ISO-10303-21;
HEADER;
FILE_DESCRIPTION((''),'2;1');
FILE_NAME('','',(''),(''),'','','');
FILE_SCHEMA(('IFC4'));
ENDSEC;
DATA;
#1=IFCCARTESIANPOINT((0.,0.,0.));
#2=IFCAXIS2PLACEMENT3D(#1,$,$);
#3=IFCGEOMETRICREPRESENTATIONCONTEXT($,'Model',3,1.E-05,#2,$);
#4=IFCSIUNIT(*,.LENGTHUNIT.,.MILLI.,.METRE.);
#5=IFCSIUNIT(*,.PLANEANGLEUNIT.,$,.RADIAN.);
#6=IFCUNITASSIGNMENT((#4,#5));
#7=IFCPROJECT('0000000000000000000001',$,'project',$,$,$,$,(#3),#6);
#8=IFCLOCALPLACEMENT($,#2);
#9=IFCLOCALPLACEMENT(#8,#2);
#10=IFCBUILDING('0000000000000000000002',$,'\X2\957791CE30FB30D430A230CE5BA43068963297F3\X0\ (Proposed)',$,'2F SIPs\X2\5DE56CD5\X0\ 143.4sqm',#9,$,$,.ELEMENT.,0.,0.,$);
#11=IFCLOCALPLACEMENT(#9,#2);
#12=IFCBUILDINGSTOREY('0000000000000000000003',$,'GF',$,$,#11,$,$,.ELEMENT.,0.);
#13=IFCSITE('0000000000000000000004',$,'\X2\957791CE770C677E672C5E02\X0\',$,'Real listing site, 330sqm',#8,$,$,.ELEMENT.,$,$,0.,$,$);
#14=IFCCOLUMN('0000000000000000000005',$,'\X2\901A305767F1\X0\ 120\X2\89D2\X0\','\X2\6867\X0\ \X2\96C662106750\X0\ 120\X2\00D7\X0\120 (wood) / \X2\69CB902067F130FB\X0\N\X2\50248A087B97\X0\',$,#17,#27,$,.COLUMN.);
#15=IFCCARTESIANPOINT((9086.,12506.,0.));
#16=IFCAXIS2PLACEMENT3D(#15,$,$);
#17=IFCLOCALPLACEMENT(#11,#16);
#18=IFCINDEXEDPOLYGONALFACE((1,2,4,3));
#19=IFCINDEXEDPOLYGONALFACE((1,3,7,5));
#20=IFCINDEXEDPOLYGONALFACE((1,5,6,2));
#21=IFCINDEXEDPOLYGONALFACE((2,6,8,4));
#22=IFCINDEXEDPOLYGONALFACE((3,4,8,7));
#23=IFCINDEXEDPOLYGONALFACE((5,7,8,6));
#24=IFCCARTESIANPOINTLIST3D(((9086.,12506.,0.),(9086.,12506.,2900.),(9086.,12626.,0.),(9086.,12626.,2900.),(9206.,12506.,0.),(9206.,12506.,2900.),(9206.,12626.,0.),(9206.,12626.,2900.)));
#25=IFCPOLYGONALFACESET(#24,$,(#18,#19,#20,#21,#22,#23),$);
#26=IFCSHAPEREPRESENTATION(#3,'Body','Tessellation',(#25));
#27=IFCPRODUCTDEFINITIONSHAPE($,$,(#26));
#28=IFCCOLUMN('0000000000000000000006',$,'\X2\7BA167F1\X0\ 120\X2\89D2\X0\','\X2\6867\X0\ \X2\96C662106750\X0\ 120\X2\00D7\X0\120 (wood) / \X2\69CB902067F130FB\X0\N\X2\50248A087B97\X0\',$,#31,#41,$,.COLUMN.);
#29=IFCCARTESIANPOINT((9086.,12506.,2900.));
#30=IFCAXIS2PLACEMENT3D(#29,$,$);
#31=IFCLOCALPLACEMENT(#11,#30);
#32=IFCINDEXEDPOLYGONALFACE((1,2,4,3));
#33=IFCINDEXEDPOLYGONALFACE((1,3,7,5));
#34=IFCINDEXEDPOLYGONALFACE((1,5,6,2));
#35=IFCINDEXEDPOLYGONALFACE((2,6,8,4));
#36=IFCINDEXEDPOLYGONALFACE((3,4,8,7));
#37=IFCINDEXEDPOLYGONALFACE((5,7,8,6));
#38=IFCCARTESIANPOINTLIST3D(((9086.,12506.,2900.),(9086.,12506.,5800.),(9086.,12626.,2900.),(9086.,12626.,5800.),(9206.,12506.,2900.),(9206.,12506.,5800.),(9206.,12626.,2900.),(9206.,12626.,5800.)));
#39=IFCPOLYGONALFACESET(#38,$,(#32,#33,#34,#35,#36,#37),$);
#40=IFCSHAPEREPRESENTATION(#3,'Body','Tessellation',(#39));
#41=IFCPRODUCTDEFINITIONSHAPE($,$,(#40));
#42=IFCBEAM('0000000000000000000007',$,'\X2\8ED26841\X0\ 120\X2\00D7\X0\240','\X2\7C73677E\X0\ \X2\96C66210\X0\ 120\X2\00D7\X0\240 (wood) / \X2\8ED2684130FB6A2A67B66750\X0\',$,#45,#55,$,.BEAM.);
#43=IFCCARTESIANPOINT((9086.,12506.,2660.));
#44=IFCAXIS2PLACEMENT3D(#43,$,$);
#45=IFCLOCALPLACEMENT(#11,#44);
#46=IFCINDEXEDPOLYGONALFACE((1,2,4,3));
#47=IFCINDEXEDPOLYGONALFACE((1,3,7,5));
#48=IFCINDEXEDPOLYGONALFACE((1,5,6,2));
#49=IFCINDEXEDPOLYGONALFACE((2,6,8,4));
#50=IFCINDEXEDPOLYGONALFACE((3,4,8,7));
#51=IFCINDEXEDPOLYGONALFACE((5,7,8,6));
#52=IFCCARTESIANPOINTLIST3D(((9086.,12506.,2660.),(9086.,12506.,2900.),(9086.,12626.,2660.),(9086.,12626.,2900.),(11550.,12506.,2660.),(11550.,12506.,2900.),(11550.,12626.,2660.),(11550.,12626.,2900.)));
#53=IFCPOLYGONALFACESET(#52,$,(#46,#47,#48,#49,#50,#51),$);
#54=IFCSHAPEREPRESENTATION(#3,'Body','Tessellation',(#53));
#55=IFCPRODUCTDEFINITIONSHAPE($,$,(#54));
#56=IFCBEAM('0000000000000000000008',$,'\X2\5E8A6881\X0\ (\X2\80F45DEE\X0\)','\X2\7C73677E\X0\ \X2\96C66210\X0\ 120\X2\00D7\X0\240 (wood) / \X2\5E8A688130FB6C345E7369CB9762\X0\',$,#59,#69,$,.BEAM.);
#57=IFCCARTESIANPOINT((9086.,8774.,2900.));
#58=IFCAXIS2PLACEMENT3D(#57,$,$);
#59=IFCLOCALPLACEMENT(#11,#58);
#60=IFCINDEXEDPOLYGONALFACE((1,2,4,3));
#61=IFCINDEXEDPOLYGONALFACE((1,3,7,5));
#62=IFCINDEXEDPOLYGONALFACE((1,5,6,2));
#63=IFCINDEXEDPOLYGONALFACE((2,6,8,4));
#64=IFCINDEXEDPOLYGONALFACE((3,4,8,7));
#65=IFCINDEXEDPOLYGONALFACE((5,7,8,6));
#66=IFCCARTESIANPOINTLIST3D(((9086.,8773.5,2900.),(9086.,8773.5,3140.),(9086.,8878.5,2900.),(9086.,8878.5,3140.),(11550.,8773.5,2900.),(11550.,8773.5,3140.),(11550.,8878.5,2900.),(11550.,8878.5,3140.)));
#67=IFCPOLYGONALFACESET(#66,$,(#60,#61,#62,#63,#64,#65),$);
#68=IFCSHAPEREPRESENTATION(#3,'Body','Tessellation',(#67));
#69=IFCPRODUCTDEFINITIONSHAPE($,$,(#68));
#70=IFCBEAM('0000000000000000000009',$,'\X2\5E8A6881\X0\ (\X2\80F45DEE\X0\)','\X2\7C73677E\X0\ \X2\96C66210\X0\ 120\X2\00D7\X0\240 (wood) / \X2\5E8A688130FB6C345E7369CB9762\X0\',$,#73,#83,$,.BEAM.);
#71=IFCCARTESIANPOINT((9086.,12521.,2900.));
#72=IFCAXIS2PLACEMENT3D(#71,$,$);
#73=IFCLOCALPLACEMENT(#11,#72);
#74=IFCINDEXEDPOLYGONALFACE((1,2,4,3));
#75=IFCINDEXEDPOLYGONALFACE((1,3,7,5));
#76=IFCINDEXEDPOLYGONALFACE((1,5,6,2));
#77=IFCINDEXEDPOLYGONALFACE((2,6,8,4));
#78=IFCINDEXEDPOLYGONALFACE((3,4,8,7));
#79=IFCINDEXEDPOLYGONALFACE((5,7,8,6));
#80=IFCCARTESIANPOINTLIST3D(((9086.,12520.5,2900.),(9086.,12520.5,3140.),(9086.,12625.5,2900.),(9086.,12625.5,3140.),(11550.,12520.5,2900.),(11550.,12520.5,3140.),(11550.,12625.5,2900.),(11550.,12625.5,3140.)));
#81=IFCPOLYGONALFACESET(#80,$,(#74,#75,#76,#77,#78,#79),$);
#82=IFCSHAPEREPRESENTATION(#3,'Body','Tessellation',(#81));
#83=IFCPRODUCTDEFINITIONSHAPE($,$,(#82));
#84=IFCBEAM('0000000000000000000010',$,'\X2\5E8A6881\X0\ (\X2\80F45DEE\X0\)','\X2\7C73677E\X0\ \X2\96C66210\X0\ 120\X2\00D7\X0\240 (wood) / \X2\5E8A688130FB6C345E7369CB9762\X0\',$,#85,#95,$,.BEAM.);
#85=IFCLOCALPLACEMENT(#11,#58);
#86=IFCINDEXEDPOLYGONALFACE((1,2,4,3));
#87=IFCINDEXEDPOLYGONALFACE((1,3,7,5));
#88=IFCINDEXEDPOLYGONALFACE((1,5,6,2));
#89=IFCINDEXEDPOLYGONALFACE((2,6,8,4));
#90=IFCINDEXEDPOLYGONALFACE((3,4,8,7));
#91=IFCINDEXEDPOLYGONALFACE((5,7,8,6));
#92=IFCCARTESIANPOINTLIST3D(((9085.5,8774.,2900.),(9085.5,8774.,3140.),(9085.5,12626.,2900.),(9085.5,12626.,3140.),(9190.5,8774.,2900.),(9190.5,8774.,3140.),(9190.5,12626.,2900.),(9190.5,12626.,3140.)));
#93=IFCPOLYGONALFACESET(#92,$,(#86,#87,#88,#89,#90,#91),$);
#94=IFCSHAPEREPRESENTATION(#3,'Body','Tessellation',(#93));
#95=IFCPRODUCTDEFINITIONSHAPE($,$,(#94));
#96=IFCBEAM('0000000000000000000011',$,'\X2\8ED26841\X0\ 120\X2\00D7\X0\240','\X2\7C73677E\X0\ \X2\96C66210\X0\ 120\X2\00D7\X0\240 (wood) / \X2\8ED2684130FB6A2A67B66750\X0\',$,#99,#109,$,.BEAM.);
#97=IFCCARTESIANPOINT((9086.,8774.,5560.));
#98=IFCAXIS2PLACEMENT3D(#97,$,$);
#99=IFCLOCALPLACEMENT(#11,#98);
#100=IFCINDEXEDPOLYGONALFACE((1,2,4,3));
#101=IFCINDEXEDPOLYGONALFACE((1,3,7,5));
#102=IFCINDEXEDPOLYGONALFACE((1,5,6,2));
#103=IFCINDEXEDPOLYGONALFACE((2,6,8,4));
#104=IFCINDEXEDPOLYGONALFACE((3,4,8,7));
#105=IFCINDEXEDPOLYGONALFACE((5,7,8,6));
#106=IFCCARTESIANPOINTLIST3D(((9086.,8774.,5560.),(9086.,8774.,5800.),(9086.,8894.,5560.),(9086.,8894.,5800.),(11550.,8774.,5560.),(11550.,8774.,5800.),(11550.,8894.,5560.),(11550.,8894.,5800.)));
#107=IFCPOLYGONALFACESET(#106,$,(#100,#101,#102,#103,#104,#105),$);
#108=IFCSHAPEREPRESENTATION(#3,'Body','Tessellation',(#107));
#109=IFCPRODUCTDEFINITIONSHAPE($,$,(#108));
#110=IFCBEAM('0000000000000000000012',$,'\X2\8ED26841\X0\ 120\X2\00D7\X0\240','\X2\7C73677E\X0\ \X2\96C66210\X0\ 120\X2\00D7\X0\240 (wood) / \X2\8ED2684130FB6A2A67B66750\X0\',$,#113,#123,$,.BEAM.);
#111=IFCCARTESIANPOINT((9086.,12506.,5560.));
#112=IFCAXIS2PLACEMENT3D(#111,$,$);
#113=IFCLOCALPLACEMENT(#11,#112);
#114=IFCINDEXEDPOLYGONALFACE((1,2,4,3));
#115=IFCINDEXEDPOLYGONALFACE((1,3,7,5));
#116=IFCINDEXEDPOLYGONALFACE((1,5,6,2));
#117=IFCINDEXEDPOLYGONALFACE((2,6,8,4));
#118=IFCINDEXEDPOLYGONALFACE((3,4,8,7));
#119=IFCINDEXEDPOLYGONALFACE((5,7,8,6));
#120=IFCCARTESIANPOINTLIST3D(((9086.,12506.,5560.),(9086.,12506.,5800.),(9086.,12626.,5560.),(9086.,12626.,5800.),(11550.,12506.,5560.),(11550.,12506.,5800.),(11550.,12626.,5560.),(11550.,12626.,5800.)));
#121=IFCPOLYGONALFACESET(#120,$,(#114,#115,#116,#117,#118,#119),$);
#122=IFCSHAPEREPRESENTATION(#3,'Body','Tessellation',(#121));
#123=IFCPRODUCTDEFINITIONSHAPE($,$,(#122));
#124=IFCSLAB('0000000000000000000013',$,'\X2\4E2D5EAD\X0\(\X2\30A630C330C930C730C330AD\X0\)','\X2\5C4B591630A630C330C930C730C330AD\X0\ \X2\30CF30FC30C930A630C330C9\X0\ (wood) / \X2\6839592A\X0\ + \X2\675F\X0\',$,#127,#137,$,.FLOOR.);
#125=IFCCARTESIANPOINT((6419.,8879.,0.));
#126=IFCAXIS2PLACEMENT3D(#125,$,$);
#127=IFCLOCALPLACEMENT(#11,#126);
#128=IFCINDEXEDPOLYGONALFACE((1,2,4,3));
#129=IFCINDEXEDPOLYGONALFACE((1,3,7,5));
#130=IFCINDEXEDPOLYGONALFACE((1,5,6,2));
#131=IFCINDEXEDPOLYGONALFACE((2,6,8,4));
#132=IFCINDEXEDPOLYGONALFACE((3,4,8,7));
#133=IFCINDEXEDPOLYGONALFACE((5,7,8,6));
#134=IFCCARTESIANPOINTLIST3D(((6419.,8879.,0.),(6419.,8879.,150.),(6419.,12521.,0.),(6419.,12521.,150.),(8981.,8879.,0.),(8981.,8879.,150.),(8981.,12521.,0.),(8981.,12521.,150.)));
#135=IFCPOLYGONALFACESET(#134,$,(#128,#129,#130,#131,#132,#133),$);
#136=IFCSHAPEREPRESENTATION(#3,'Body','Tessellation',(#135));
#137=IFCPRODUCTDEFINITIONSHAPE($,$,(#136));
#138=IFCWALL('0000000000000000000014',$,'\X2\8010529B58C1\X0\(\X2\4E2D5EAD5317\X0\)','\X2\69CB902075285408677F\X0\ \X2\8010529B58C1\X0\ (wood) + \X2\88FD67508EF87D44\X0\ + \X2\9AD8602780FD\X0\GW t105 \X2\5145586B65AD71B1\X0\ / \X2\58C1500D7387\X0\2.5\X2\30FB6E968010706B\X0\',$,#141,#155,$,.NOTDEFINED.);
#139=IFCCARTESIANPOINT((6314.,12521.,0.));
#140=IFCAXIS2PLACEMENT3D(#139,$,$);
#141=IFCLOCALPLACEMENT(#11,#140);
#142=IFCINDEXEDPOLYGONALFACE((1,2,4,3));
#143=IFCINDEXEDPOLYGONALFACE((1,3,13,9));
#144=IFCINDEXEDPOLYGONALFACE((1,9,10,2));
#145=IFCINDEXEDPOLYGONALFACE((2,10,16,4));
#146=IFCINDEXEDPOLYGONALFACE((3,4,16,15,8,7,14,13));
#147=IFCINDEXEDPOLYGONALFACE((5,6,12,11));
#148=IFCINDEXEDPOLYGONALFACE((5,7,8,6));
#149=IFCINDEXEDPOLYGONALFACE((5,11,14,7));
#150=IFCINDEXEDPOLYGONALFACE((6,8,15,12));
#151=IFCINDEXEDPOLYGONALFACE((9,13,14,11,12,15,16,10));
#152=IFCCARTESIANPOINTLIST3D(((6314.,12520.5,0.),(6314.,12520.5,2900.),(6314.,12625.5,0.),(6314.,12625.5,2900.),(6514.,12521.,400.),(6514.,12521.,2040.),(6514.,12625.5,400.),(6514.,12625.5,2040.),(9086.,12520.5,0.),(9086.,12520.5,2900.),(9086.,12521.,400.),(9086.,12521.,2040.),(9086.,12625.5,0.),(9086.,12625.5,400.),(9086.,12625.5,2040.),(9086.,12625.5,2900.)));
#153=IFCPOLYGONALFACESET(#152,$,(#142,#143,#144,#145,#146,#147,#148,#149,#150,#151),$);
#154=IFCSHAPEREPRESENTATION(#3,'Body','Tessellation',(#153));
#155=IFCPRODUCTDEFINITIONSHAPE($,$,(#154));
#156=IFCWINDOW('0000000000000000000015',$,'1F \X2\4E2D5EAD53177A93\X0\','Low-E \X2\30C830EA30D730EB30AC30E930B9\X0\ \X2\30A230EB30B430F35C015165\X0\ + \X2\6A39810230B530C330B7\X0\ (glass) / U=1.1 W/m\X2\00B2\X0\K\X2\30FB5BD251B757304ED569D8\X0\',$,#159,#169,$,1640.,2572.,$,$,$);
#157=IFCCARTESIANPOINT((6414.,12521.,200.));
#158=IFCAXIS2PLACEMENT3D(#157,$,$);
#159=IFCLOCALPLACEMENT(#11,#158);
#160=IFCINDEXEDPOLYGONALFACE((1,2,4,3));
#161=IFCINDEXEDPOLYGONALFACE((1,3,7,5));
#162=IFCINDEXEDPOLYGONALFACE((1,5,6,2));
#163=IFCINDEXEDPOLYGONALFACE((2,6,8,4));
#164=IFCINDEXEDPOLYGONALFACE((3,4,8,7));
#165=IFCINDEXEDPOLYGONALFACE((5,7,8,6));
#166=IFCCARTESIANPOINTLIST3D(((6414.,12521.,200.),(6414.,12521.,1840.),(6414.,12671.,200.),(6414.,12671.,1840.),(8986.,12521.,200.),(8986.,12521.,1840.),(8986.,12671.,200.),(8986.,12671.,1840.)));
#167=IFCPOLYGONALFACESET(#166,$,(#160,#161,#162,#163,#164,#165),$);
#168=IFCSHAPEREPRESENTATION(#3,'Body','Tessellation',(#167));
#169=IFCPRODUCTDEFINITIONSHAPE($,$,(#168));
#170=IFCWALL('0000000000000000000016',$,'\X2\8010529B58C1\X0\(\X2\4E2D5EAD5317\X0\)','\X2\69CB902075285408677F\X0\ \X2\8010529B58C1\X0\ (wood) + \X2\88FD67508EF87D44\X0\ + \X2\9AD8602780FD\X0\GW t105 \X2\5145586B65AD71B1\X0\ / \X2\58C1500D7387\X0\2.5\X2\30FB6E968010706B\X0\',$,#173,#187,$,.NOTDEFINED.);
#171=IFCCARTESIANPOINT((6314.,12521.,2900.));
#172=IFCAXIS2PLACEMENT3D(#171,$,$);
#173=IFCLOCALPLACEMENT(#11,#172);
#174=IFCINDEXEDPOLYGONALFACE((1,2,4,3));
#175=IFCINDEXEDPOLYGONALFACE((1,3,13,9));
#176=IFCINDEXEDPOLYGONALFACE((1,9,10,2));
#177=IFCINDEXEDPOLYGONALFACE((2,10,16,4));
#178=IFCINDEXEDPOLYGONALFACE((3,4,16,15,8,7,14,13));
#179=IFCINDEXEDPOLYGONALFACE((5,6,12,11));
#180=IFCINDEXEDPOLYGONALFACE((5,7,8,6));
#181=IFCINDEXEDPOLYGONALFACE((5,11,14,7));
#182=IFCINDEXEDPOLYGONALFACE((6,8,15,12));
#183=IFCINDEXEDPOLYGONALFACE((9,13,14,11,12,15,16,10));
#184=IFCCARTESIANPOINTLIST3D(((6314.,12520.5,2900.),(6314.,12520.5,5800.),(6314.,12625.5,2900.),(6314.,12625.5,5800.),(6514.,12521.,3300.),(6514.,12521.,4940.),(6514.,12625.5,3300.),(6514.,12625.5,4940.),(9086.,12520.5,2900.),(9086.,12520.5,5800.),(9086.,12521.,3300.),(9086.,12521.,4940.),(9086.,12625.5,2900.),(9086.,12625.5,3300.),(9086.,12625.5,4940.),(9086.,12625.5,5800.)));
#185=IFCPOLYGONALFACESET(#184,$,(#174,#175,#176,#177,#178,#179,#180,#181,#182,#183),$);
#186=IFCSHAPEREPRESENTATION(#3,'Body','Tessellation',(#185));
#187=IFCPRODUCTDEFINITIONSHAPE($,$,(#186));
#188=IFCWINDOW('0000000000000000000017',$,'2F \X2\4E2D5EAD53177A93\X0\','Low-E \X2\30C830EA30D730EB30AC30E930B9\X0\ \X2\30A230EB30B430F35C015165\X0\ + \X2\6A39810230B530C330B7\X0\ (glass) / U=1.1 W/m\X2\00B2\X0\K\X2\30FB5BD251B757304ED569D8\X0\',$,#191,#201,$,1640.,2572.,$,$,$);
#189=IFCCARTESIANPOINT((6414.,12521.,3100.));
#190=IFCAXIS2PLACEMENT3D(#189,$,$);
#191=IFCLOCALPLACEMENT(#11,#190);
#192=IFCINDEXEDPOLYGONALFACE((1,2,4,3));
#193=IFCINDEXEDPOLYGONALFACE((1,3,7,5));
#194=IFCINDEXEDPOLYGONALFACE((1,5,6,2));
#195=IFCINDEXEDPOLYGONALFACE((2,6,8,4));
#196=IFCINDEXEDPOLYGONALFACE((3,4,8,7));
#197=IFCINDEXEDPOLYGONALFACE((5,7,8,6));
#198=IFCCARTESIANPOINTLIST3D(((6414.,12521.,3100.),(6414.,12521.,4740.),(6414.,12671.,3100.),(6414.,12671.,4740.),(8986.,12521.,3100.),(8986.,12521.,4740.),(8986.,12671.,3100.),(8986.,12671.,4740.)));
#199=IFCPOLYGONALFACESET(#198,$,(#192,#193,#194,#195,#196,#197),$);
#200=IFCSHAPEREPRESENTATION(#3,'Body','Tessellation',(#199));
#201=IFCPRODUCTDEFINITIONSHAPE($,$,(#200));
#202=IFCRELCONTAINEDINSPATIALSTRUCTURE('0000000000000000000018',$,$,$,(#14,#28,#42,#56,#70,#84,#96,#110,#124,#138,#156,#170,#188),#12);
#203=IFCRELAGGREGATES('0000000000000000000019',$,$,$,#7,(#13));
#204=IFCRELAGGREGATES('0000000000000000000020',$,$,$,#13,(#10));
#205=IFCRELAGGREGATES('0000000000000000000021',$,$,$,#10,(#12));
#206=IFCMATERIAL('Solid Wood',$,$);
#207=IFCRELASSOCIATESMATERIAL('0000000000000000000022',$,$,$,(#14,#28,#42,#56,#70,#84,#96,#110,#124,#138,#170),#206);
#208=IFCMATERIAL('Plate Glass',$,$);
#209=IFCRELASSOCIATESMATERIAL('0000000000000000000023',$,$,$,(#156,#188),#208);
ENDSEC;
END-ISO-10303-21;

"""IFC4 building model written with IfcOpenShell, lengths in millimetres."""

from ifc_helpers import new_model, si_unit, frame, frame_2d, origin, place, context, project, spatial, rectangle, extrude, material, element, fill, save


model = new_model("IFC4")

# Units and contexts
model_context = context("Model", 3, precision=1e-05, world=origin())
ifc_project = project(units=[si_unit("LENGTHUNIT", "METRE", prefix="MILLI"), si_unit("PLANEANGLEUNIT", "RADIAN")], contexts=[model_context])

# Site, building, storey
site_placement = place(None, origin())
site = spatial("IfcSite", under=ifc_project, at=site_placement, Name="長野県松本市", ObjectType="Real listing site, 330sqm", CompositionType="ELEMENT", RefElevation=0.0)
building_placement = place(site_placement, origin())
building = spatial("IfcBuilding", under=site, at=building_placement, Name="長野・ピアノ室と防音 (Proposed)", ObjectType="2F SIPs工法 143.4sqm", CompositionType="ELEMENT", ElevationOfRefHeight=0.0, ElevationOfTerrain=0.0)
storey_placement = place(building_placement, origin())
storey = spatial("IfcBuildingStorey", under=building, at=storey_placement, Name="GF", CompositionType="ELEMENT", Elevation=0.0)

# Columns
ifc_material_1 = material(Name="Solid Wood")
column_1_placement = place(storey_placement, frame((9086.0, 12506.0, 0.0)))
element("IfcColumn", 1, at=column_1_placement, inside=storey, material=ifc_material_1, Name="通し柱 120角", Description="桧 集成材 120×120 (wood) / 構造柱・N値計算", PredefinedType="COLUMN", context=model_context, shape_type="SweptSolid", body=[
    extrude(rectangle(XDim=120.0, YDim=120.0, at=frame_2d((60.0, 60.0))), frame((9086.0, 12506.0, 0.0)), (0.0, 0.0, 1.0), 2900.0),
])
column_2_placement = place(storey_placement, frame((9086.0, 12506.0, 2900.0)))
element("IfcColumn", 2, at=column_2_placement, inside=storey, material=ifc_material_1, Name="管柱 120角", Description="桧 集成材 120×120 (wood) / 構造柱・N値計算", PredefinedType="COLUMN", context=model_context, shape_type="SweptSolid", body=[
    extrude(rectangle(XDim=120.0, YDim=120.0, at=frame_2d((60.0, 60.0))), frame((9086.0, 12506.0, 2900.0)), (0.0, 0.0, 1.0), 2900.0),
])

# Beams
beam_1_placement = place(storey_placement, frame((9086.0, 12506.0, 2660.0)))
element("IfcBeam", 3, at=beam_1_placement, inside=storey, material=ifc_material_1, Name="軒桁 120×240", Description="米松 集成 120×240 (wood) / 軒桁・横架材", PredefinedType="BEAM", context=model_context, shape_type="SweptSolid", body=[
    extrude(rectangle(XDim=2464.0, YDim=120.0, at=frame_2d((1232.0, 60.0))), frame((9086.0, 12506.0, 2660.0)), (0.0, 0.0, 1.0), 240.0),
])
beam_2_placement = place(storey_placement, frame((9086.0, 8774.0, 2900.0)))
element("IfcBeam", 4, at=beam_2_placement, inside=storey, material=ifc_material_1, Name="床梁 (胴差)", Description="米松 集成 120×240 (wood) / 床梁・水平構面", PredefinedType="BEAM", context=model_context, shape_type="SweptSolid", body=[
    extrude(rectangle(XDim=2464.0, YDim=105.0, at=frame_2d((1232.0, 52.0))), frame((9086.0, 8774.0, 2900.0)), (0.0, 0.0, 1.0), 240.0),
])
beam_3_placement = place(storey_placement, frame((9086.0, 12521.0, 2900.0)))
element("IfcBeam", 5, at=beam_3_placement, inside=storey, material=ifc_material_1, Name="床梁 (胴差)", Description="米松 集成 120×240 (wood) / 床梁・水平構面", PredefinedType="BEAM", context=model_context, shape_type="SweptSolid", body=[
    extrude(rectangle(XDim=2464.0, YDim=105.0, at=frame_2d((1232.0, 52.0))), frame((9086.0, 12521.0, 2900.0)), (0.0, 0.0, 1.0), 240.0),
])
beam_4_placement = place(storey_placement, frame((9086.0, 8774.0, 2900.0)))
element("IfcBeam", 6, at=beam_4_placement, inside=storey, material=ifc_material_1, Name="床梁 (胴差)", Description="米松 集成 120×240 (wood) / 床梁・水平構面", PredefinedType="BEAM", context=model_context, shape_type="SweptSolid", body=[
    extrude(rectangle(XDim=105.0, YDim=3852.0, at=frame_2d((52.0, 1926.0))), frame((9086.0, 8774.0, 2900.0)), (0.0, 0.0, 1.0), 240.0),
])
beam_5_placement = place(storey_placement, frame((9086.0, 8774.0, 5560.0)))
element("IfcBeam", 7, at=beam_5_placement, inside=storey, material=ifc_material_1, Name="軒桁 120×240", Description="米松 集成 120×240 (wood) / 軒桁・横架材", PredefinedType="BEAM", context=model_context, shape_type="SweptSolid", body=[
    extrude(rectangle(XDim=2464.0, YDim=120.0, at=frame_2d((1232.0, 60.0))), frame((9086.0, 8774.0, 5560.0)), (0.0, 0.0, 1.0), 240.0),
])
beam_6_placement = place(storey_placement, frame((9086.0, 12506.0, 5560.0)))
element("IfcBeam", 8, at=beam_6_placement, inside=storey, material=ifc_material_1, Name="軒桁 120×240", Description="米松 集成 120×240 (wood) / 軒桁・横架材", PredefinedType="BEAM", context=model_context, shape_type="SweptSolid", body=[
    extrude(rectangle(XDim=2464.0, YDim=120.0, at=frame_2d((1232.0, 60.0))), frame((9086.0, 12506.0, 5560.0)), (0.0, 0.0, 1.0), 240.0),
])

# Slab
slab_placement = place(storey_placement, frame((6419.0, 8879.0, 0.0)))
element("IfcSlab", 9, at=slab_placement, inside=storey, material=ifc_material_1, Name="中庭(ウッドデッキ)", Description="屋外ウッドデッキ ハードウッド (wood) / 根太 + 束", PredefinedType="FLOOR", context=model_context, shape_type="SweptSolid", body=[
    extrude(rectangle(XDim=2562.0, YDim=3642.0, at=frame_2d((1281.0, 1821.0))), frame((6419.0, 8879.0, 0.0)), (0.0, 0.0, 1.0), 150.0),
])

# Wall, opening, window
wall_1_placement = place(storey_placement, frame((6314.0, 12521.0, 0.0)))
wall_1 = element("IfcWall", 10, at=wall_1_placement, inside=storey, material=ifc_material_1, Name="耐力壁(中庭北)", Description="構造用合板 耐力壁 (wood) + 製材軸組 + 高性能GW t105 充填断熱 / 壁倍率2.5・準耐火", PredefinedType="NOTDEFINED", context=model_context, shape_type="SweptSolid", body=[
    extrude(rectangle(XDim=2772.0, YDim=105.0, at=frame_2d((1386.0, 52.0))), frame((6314.0, 12521.0, 0.0)), (0.0, 0.0, 1.0), 2900.0),
])
opening_1_placement = place(storey_placement, frame((6414.0, 12521.0, 200.0)))
opening_1 = element("IfcOpeningElement", 11, at=opening_1_placement, cuts=wall_1, PredefinedType="NOTDEFINED", context=model_context, shape_type="SweptSolid", body=[
    extrude(rectangle(XDim=2572.0, YDim=150.0, at=frame_2d((1286.0, 75.0))), frame((6414.0, 12521.0, 200.0)), (0.0, 0.0, 1.0), 1640.0),
])
ifc_material_2 = material(Name="Plate Glass")
window_1_placement = place(storey_placement, frame((6414.0, 12521.0, 200.0)))
window_1 = element("IfcWindow", 12, at=window_1_placement, inside=storey, material=ifc_material_2, Name="1F 中庭北窓", Description="Low-E トリプルガラス アルゴン封入 + 樹脂サッシ (glass) / U=1.1 W/m²K・寒冷地仕様", OverallHeight=1640.0, OverallWidth=2572.0, context=model_context, shape_type="SweptSolid", body=[
    extrude(rectangle(XDim=2572.0, YDim=150.0, at=frame_2d((1286.0, 75.0))), frame((6414.0, 12521.0, 200.0)), (0.0, 0.0, 1.0), 1640.0),
])
fill(opening_1, window_1)

# Wall, opening, window
wall_2_placement = place(storey_placement, frame((6314.0, 12521.0, 2900.0)))
wall_2 = element("IfcWall", 13, at=wall_2_placement, inside=storey, material=ifc_material_1, Name="耐力壁(中庭北)", Description="構造用合板 耐力壁 (wood) + 製材軸組 + 高性能GW t105 充填断熱 / 壁倍率2.5・準耐火", PredefinedType="NOTDEFINED", context=model_context, shape_type="SweptSolid", body=[
    extrude(rectangle(XDim=2772.0, YDim=105.0, at=frame_2d((1386.0, 52.0))), frame((6314.0, 12521.0, 2900.0)), (0.0, 0.0, 1.0), 2900.0),
])
opening_2_placement = place(storey_placement, frame((6414.0, 12521.0, 3100.0)))
opening_2 = element("IfcOpeningElement", 14, at=opening_2_placement, cuts=wall_2, PredefinedType="NOTDEFINED", context=model_context, shape_type="SweptSolid", body=[
    extrude(rectangle(XDim=2572.0, YDim=150.0, at=frame_2d((1286.0, 75.0))), frame((6414.0, 12521.0, 3100.0)), (0.0, 0.0, 1.0), 1640.0),
])
window_2_placement = place(storey_placement, frame((6414.0, 12521.0, 3100.0)))
window_2 = element("IfcWindow", 15, at=window_2_placement, inside=storey, material=ifc_material_2, Name="2F 中庭北窓", Description="Low-E トリプルガラス アルゴン封入 + 樹脂サッシ (glass) / U=1.1 W/m²K・寒冷地仕様", OverallHeight=1640.0, OverallWidth=2572.0, context=model_context, shape_type="SweptSolid", body=[
    extrude(rectangle(XDim=2572.0, YDim=150.0, at=frame_2d((1286.0, 75.0))), frame((6414.0, 12521.0, 3100.0)), (0.0, 0.0, 1.0), 1640.0),
])
fill(opening_2, window_2)

save(model, "model.ifc")
